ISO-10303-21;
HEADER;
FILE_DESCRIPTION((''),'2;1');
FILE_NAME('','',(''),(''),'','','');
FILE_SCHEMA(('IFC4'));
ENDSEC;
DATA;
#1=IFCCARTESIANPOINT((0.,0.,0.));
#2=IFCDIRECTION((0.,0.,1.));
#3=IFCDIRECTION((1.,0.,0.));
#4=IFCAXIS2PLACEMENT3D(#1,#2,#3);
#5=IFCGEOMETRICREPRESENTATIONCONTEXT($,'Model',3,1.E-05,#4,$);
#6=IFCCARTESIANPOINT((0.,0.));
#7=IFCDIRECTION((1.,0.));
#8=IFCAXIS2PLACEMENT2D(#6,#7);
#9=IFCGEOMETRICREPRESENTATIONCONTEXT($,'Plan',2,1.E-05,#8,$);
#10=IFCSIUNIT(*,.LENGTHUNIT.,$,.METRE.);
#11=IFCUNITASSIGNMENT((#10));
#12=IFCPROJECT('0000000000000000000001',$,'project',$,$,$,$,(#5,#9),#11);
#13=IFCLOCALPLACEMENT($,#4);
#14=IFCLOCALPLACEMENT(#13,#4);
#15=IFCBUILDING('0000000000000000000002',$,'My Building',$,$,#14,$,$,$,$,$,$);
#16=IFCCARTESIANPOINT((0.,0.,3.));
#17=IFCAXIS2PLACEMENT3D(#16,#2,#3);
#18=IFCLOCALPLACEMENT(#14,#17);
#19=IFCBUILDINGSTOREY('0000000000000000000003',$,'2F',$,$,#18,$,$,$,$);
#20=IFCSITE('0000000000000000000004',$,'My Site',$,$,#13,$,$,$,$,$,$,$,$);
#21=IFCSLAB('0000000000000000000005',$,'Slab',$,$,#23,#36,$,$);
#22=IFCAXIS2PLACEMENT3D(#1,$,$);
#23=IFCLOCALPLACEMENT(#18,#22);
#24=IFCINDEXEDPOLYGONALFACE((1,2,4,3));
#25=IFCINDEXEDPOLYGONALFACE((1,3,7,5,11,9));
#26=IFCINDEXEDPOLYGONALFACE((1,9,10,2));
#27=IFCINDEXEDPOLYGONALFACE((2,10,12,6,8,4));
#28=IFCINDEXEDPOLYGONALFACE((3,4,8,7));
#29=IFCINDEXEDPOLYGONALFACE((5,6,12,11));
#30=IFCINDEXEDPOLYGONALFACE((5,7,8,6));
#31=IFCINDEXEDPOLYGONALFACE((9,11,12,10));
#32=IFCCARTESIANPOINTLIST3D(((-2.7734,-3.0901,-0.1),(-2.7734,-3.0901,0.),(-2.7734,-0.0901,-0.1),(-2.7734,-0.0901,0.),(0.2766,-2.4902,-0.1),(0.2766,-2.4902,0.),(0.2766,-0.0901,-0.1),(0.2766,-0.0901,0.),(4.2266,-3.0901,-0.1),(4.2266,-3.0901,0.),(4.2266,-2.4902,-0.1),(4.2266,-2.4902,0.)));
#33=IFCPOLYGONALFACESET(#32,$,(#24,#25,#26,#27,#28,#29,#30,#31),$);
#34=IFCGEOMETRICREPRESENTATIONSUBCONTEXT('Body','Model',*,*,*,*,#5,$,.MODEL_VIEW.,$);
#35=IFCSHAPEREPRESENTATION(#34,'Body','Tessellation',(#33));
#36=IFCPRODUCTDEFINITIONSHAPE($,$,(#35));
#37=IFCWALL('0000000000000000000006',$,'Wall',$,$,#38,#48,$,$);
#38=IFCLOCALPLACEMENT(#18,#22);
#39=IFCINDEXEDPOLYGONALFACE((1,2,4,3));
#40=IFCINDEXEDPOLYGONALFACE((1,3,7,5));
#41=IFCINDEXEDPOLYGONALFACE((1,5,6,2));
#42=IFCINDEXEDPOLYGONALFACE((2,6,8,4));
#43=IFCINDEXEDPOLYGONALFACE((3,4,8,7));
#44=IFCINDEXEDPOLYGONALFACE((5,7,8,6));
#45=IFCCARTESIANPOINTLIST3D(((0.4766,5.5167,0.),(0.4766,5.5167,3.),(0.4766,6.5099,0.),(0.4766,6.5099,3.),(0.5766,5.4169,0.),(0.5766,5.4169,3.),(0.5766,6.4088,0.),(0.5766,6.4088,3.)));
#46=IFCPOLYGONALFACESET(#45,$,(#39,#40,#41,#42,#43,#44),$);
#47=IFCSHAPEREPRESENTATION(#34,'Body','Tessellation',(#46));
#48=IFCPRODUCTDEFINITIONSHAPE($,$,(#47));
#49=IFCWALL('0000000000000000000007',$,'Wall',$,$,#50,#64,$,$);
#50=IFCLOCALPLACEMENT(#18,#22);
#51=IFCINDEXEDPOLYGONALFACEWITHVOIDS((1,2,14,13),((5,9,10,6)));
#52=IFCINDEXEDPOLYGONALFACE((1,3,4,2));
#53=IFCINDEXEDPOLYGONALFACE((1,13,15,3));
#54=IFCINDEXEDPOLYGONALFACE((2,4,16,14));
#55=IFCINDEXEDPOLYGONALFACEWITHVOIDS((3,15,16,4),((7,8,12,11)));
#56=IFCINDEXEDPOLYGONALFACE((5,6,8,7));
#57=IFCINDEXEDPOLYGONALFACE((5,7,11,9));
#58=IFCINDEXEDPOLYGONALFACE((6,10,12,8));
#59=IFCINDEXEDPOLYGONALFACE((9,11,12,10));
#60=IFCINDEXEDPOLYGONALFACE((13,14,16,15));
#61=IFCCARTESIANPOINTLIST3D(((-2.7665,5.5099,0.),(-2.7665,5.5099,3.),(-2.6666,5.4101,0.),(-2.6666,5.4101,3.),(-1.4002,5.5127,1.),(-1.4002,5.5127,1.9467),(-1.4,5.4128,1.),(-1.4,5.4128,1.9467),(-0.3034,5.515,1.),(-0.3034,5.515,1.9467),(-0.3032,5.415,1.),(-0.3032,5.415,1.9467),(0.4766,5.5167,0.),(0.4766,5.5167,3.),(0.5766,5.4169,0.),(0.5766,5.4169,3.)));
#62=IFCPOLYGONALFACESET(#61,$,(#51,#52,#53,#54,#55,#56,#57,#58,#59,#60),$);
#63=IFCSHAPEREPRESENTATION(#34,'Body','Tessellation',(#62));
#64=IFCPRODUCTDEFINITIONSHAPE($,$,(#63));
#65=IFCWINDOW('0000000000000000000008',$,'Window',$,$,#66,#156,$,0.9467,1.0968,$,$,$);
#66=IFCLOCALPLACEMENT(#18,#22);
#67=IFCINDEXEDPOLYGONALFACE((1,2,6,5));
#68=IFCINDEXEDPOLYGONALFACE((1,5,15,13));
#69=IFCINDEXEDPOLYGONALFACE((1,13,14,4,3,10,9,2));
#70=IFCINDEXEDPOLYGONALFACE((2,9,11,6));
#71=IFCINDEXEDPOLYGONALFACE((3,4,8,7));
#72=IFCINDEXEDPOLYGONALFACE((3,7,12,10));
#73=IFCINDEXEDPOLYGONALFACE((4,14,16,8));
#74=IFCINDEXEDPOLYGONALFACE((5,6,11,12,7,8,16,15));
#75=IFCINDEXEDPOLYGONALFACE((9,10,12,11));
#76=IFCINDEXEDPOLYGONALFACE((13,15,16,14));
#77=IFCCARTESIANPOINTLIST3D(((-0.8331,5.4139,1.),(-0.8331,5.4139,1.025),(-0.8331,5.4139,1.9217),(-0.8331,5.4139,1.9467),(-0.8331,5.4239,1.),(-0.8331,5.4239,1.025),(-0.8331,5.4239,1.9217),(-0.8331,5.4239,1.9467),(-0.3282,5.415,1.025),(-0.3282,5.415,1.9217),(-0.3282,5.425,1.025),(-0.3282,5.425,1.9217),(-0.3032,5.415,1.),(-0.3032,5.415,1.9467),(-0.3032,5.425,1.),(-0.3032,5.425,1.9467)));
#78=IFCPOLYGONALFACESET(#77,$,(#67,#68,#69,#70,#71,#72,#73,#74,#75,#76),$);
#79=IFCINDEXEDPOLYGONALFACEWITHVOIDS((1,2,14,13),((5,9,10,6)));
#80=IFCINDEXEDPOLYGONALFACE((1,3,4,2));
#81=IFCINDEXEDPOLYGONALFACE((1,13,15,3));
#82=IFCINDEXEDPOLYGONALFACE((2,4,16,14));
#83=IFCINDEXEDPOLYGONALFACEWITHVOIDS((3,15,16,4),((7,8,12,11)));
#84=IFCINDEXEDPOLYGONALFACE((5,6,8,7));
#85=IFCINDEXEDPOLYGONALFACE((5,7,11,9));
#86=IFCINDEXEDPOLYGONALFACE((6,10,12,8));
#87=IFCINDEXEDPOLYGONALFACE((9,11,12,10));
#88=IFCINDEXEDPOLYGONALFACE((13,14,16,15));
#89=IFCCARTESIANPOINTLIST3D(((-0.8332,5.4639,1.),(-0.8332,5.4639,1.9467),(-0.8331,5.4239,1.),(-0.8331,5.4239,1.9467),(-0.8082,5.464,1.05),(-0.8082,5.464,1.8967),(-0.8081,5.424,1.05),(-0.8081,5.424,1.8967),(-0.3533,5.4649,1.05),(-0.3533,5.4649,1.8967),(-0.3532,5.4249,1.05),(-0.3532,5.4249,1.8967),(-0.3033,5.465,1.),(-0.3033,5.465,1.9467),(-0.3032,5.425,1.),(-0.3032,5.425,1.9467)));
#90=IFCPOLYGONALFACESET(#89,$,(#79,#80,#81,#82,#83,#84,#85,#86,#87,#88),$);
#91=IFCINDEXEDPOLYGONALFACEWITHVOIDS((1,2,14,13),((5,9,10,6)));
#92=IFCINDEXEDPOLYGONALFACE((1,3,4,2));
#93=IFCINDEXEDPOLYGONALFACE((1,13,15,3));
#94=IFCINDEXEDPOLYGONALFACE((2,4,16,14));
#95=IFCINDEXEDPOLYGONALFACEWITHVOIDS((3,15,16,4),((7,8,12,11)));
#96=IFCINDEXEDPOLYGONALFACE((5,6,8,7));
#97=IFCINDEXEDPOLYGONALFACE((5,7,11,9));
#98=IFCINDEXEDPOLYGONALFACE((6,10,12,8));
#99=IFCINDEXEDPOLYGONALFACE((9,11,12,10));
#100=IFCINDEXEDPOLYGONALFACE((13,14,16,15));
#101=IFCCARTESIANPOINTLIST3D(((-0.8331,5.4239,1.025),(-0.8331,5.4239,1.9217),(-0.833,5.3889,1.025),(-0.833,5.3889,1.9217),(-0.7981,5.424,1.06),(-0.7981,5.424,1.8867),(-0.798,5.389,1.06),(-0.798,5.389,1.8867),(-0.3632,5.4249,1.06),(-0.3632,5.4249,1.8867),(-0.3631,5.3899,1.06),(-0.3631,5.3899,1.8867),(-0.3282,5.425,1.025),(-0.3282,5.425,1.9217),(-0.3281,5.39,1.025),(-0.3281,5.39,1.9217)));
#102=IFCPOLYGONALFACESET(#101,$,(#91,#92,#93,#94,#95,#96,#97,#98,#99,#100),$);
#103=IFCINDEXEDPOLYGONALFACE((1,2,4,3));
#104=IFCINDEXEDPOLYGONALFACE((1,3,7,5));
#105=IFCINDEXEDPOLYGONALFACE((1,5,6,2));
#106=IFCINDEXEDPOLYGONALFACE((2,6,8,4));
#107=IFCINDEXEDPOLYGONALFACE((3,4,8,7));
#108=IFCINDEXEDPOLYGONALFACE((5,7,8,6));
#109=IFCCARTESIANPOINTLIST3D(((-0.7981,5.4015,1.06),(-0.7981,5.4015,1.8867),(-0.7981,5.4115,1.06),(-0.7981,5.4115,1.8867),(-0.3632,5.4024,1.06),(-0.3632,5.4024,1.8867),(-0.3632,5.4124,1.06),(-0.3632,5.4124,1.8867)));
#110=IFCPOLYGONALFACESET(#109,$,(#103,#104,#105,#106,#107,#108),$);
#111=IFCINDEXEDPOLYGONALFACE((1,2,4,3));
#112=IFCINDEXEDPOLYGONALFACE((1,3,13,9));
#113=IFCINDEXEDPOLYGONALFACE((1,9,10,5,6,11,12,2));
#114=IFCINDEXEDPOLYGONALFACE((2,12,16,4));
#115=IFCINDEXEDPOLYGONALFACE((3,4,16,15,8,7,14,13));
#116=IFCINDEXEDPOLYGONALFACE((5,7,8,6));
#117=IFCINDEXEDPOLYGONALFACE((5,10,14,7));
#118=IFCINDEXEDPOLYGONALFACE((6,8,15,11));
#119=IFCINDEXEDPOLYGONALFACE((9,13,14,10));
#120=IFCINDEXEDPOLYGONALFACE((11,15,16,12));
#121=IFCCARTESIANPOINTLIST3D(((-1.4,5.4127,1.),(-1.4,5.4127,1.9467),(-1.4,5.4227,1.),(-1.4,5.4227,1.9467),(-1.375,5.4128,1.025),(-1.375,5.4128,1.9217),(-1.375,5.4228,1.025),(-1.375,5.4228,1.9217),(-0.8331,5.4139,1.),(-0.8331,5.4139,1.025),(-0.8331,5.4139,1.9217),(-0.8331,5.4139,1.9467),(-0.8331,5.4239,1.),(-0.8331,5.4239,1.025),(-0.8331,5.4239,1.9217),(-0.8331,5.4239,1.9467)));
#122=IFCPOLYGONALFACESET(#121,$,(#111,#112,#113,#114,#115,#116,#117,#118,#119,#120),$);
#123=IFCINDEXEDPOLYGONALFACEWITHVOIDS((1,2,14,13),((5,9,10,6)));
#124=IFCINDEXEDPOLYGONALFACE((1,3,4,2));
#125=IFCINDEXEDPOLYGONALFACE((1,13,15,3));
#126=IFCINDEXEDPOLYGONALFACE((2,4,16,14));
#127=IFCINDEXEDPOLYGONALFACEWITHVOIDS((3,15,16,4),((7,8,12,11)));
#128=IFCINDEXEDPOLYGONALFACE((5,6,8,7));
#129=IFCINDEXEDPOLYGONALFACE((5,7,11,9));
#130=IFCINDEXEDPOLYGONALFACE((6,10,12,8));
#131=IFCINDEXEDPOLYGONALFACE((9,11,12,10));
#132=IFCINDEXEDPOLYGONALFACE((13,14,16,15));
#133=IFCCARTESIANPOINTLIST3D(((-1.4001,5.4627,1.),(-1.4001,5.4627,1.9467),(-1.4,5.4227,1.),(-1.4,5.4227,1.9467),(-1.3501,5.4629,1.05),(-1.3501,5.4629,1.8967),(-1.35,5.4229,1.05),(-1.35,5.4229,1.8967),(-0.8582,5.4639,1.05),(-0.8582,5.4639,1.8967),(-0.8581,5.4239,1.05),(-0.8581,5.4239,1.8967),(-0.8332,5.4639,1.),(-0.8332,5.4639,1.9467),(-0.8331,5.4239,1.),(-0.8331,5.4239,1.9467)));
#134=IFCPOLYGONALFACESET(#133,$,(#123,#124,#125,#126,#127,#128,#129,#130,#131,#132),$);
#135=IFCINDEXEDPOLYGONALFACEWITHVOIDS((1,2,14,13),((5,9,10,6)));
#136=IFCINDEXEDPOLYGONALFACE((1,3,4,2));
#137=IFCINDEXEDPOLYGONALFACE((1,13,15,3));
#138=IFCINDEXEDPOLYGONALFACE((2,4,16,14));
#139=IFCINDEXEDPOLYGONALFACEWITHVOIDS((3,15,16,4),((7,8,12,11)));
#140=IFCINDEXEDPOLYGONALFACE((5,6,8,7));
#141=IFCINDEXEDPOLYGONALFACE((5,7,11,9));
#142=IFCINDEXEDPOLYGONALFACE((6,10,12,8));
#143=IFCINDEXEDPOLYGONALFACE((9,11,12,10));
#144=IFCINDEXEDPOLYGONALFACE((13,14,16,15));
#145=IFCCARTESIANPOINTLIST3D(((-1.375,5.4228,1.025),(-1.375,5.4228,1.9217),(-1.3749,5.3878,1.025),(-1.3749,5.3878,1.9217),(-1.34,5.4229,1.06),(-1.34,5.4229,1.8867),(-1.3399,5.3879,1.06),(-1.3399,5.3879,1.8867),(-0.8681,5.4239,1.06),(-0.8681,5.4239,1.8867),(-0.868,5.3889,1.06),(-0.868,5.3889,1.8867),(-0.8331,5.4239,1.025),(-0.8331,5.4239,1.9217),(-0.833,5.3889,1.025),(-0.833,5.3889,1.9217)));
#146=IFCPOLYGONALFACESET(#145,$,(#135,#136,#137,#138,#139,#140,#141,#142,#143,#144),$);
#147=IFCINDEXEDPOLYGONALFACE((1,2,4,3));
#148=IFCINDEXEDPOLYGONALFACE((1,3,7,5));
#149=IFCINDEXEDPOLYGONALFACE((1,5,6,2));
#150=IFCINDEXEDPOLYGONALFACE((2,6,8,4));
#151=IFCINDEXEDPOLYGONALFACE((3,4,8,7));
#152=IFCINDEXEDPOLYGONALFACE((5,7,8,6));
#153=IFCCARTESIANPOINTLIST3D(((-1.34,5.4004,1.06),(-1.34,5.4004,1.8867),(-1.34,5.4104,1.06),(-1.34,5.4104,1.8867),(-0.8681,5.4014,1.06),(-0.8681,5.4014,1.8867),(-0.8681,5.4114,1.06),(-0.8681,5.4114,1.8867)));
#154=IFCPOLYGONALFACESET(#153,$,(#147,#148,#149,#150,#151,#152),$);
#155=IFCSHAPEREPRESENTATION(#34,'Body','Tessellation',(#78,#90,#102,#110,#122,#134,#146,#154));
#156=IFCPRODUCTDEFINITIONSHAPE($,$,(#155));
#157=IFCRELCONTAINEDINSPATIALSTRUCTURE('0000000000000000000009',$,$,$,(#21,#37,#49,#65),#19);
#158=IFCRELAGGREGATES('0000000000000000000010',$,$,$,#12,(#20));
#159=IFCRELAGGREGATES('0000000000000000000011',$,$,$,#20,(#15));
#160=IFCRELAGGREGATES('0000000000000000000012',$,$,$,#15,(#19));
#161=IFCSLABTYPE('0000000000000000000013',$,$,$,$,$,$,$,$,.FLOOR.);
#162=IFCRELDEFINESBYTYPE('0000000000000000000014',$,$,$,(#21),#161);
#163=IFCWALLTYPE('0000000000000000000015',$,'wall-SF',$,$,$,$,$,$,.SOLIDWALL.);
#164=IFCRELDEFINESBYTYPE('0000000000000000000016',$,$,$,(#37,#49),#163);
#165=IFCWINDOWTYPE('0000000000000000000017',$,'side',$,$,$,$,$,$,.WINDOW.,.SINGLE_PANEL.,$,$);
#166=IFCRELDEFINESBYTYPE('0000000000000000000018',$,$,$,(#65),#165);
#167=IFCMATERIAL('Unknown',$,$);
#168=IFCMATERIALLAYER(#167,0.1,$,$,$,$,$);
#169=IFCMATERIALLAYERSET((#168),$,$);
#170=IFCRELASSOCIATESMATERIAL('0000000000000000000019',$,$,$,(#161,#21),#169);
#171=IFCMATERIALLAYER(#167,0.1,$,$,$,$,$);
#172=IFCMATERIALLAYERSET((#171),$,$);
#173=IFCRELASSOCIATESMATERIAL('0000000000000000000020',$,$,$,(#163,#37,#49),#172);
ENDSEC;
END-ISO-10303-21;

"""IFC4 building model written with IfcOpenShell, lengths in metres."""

from ifc_helpers import new_model, entity, si_unit, frame, origin_with_axes, origin_2d_with_axis, place, context, subcontext, project, spatial, line, indexed_curve, outline, extrude, shape, source, transform, mapped, material, layer, layer_set, layer_usage, type_object, type_shapes, element, fill, save


model = new_model("IFC4")

# Units and contexts
model_context = context("Model", 3, precision=1e-05, world=origin_with_axes())
plan_context = context("Plan", 2, precision=1e-05, world=origin_2d_with_axis())
body_context_1 = subcontext(model_context, "Body", "Model", "MODEL_VIEW")
body_context_2 = subcontext(plan_context, "Body", "Plan", "PLAN_VIEW")
ifc_project = project(units=[si_unit("LENGTHUNIT", "METRE")], contexts=[model_context, plan_context])

# Site, building, storey
site_placement = place(None, origin_with_axes())
site = spatial("IfcSite", under=ifc_project, at=site_placement, Name="My Site")
building_placement = place(site_placement, origin_with_axes())
building = spatial("IfcBuilding", under=site, at=building_placement, Name="My Building")
storey_placement = place(building_placement, frame((0.0, 0.0, 3.0), z_axis=(0.0, 0.0, 1.0), x_axis=(1.0, 0.0, 0.0)))
storey = spatial("IfcBuildingStorey", under=building, at=storey_placement, Name="2F")

# Slab
ifc_material = material(Name="Unknown")
ifc_layer_1 = layer(ifc_material, 0.1)
ifc_layer_set_1 = layer_set([ifc_layer_1])
ifc_layer_usage_1 = layer_usage(ifc_layer_set_1, "AXIS3", "POSITIVE", -0.1)
slab_type = type_object("IfcSlabType", PredefinedType="FLOOR", material=ifc_layer_set_1)
slab_placement = place(storey_placement, frame((-2.7734, -0.0901, 0.0), z_axis=(0.0, 0.0, 1.0), x_axis=(1.0, 0.0, 0.0)))
element("IfcSlab", 1, at=slab_placement, inside=storey, type_object=slab_type, material=ifc_layer_usage_1, Name="Slab", context=body_context_1, shape_type="SweptSolid", body=[
    extrude(outline(indexed_curve([(0.0, 0.0), (0.0, -3.0), (7.0, -3.0), (7.0, -2.4001), (3.05, -2.4001), (3.05, 0.0), (0.0, 0.0), (0.0, 0.0)])), frame((0.0, 0.0, -0.1), z_axis=(0.0, 0.0, 1.0), x_axis=(1.0, 0.0, 0.0)), (0.0, 0.0, 1.0), 0.1),
])

# Wall
ifc_layer_2 = layer(ifc_material, 0.1)
ifc_layer_set_2 = layer_set([ifc_layer_2])
ifc_layer_usage_2 = layer_usage(ifc_layer_set_2, "AXIS2", "POSITIVE", 0.0)
wall_type = type_object("IfcWallType", Name="wall-SF", PredefinedType="SOLIDWALL", material=ifc_layer_set_2)
wall_1_placement = place(storey_placement, frame((0.4766, 6.5099, 0.0), z_axis=(0.0, 0.0, 1.0), x_axis=(0.0, -1.0, 0.0)))
element("IfcWall", 2, at=wall_1_placement, inside=storey, type_object=wall_type, material=ifc_layer_usage_2, Name="Wall", context=body_context_1, shape_type="SweptSolid", body=[
    extrude(outline(indexed_curve([(0.0, 0.0), (0.1011, 0.1), (1.093, 0.1), (0.9932, 0.0)], segments=[line(1, 2, 3, 4, 1)])), origin_with_axes(), (0.0, 0.0, 1.0), 3.0),
])

# Wall, opening, window
ifc_layer_usage_3 = layer_usage(ifc_layer_set_2, "AXIS2", "POSITIVE", 0.0)
wall_2_placement = place(storey_placement, frame((0.4766, 5.5167, 0.0), z_axis=(0.0, 0.0, 1.0), x_axis=(-0.999998, -0.00209, 0.0)))
wall_2 = element("IfcWall", 3, at=wall_2_placement, inside=storey, type_object=wall_type, material=ifc_layer_usage_3, Name="Wall", context=body_context_1, shape_type="SweptSolid", body=[
    extrude(outline(indexed_curve([(0.0, 0.0), (-0.0998, 0.1), (3.1434, 0.1), (3.2431, 0.0)], segments=[line(1, 2, 3, 4, 1)])), origin_with_axes(), (0.0, 0.0, 1.0), 3.0),
])
shared_shape_1 = source(origin_with_axes(), body_context_1, "Body", "SweptSolid", [
    extrude(outline(indexed_curve([(0.0, 0.0), (1.0968, 0.0), (1.0968, 0.9467), (0.0, 0.9467)], segments=[line(1, 2, 3, 4, 1)])), frame((0.0, -0.6, 0.0), z_axis=(0.0, -1.0, 0.0), x_axis=(1.0, 0.0, 0.0)), (0.0, 0.0, -1.0), 1.2),
])
opening_1_placement = place(wall_2_placement, frame((0.78, 0.0, 1.0), z_axis=(0.0, 0.0, 1.0), x_axis=(1.0, 0.0, 0.0)))
opening_1 = element("IfcOpeningElement", 4, at=opening_1_placement, cuts=wall_2, PredefinedType="OPENING", context=body_context_1, shape_type="MappedRepresentation", body=[
    mapped(shared_shape_1, transform((0.0, 0.0, 0.0), x_axis=(1.0, 0.0, 0.0), y_axis=(0.0, 1.0, 0.0), z_axis=(0.0, 0.0, 1.0), scale=1.0)),
])
window_type_1 = type_object("IfcWindowType", Name="side", PartitioningType="SINGLE_PANEL", PredefinedType="WINDOW")
shared_shape_2 = source(origin_with_axes(), body_context_1, "Body", "SweptSolid", [
    extrude(outline(indexed_curve([(0.5299, 0.0), (0.0, 0.0), (0.0, 0.9467), (0.5299, 0.9467), (0.5299, 0.9217), (0.025, 0.9217), (0.025, 0.025), (0.5299, 0.025)], segments=[line(1, 2, 3, 4, 5, 6, 7, 8, 1)])), frame((0.0, 0.09, 0.0), z_axis=(0.0, -1.0, 0.0), x_axis=(1.0, 0.0, 0.0)), (0.0, 0.0, -1.0), 0.01),
    extrude(outline(indexed_curve([(0.0, 0.0), (0.5299, 0.0), (0.5299, 0.9467), (0.0, 0.9467)], segments=[line(1, 2, 3, 4, 1)]), holes=[indexed_curve([(0.05, 0.05), (0.5049, 0.05), (0.5049, 0.8967), (0.05, 0.8967)], segments=[line(1, 2, 3, 4, 1)])]), frame((0.0, 0.05, 0.0), z_axis=(0.0, -1.0, 0.0), x_axis=(1.0, 0.0, 0.0)), (0.0, 0.0, -1.0), 0.04),
    extrude(outline(indexed_curve([(0.0, 0.0), (0.5049, 0.0), (0.5049, 0.8967), (0.0, 0.8967)], segments=[line(1, 2, 3, 4, 1)]), holes=[indexed_curve([(0.035, 0.035), (0.4699, 0.035), (0.4699, 0.8617), (0.035, 0.8617)], segments=[line(1, 2, 3, 4, 1)])]), frame((0.025, 0.09, 0.025), z_axis=(0.0, -1.0, 0.0), x_axis=(1.0, 0.0, 0.0)), (0.0, 0.0, -1.0), 0.035),
    extrude(outline(indexed_curve([(0.035, 0.035), (0.4699, 0.035), (0.4699, 0.8617), (0.035, 0.8617)], segments=[line(1, 2, 3, 4, 1)])), frame((0.025, 0.1025, 0.025), z_axis=(0.0, -1.0, 0.0), x_axis=(1.0, 0.0, 0.0)), (0.0, 0.0, -1.0), 0.01),
    extrude(outline(indexed_curve([(0.0, 0.9467), (0.5669, 0.9467), (0.5669, 0.0), (0.0, 0.0), (0.0, 0.025), (0.5419, 0.025), (0.5419, 0.9217), (0.0, 0.9217)], segments=[line(1, 2, 3, 4, 5, 6, 7, 8, 1)])), frame((0.5299, 0.09, 0.0), z_axis=(0.0, -1.0, 0.0), x_axis=(1.0, 0.0, 0.0)), (0.0, 0.0, -1.0), 0.01),
    extrude(outline(indexed_curve([(0.0, 0.0), (0.5669, 0.0), (0.5669, 0.9467), (0.0, 0.9467)], segments=[line(1, 2, 3, 4, 1)]), holes=[indexed_curve([(0.025, 0.05), (0.5169, 0.05), (0.5169, 0.8967), (0.025, 0.8967)], segments=[line(1, 2, 3, 4, 1)])]), frame((0.5299, 0.05, 0.0), z_axis=(0.0, -1.0, 0.0), x_axis=(1.0, 0.0, 0.0)), (0.0, 0.0, -1.0), 0.04),
    extrude(outline(indexed_curve([(0.0, 0.0), (0.5419, 0.0), (0.5419, 0.8967), (0.0, 0.8967)], segments=[line(1, 2, 3, 4, 1)]), holes=[indexed_curve([(0.035, 0.035), (0.5069, 0.035), (0.5069, 0.8617), (0.035, 0.8617)], segments=[line(1, 2, 3, 4, 1)])]), frame((0.5299, 0.09, 0.025), z_axis=(0.0, -1.0, 0.0), x_axis=(1.0, 0.0, 0.0)), (0.0, 0.0, -1.0), 0.035),
    extrude(outline(indexed_curve([(0.035, 0.035), (0.5069, 0.035), (0.5069, 0.8617), (0.035, 0.8617)], segments=[line(1, 2, 3, 4, 1)])), frame((0.5299, 0.1025, 0.025), z_axis=(0.0, -1.0, 0.0), x_axis=(1.0, 0.0, 0.0)), (0.0, 0.0, -1.0), 0.01),
])
shared_shape_3 = source(origin_with_axes(), body_context_2, "Body", "Curve2D", [
    entity("IfcIndexedPolyCurve", entity("IfcCartesianPointList2D", [[0.05, 0.05], [0.5049, 0.05]])),
    entity("IfcIndexedPolyCurve", entity("IfcCartesianPointList2D", [[0.0, 0.1], [0.025, 0.1], [0.025, 0.09], [0.05, 0.09], [0.05, 0.05], [0.0, 0.05]]), [entity("IfcLineIndex", [1, 2, 3, 4, 5, 6, 1])]),
    entity("IfcIndexedPolyCurve", entity("IfcCartesianPointList2D", [[0.5299, 0.1], [0.5299, 0.1], [0.5299, 0.09], [0.5049, 0.09], [0.5049, 0.05], [0.5299, 0.05]])),
    entity("IfcIndexedPolyCurve", entity("IfcCartesianPointList2D", [[0.025, 0.09], [0.06, 0.09], [0.06, 0.125], [0.025, 0.125]]), [entity("IfcLineIndex", [1, 2, 3, 4, 1])]),
    entity("IfcIndexedPolyCurve", entity("IfcCartesianPointList2D", [[0.5299, 0.09], [0.4949, 0.09], [0.4949, 0.125], [0.5299, 0.125]]), [entity("IfcLineIndex", [1, 2, 3, 4, 1])]),
    entity("IfcIndexedPolyCurve", entity("IfcCartesianPointList2D", [[0.06, 0.09], [0.4949, 0.09]])),
    entity("IfcIndexedPolyCurve", entity("IfcCartesianPointList2D", [[0.06, 0.125], [0.4949, 0.125]])),
    entity("IfcIndexedPolyCurve", entity("IfcCartesianPointList2D", [[0.06, 0.1075], [0.4949, 0.1075]])),
    entity("IfcIndexedPolyCurve", entity("IfcCartesianPointList2D", [[0.5549, 0.05], [1.0468, 0.05]])),
    entity("IfcIndexedPolyCurve", entity("IfcCartesianPointList2D", [[0.5299, 0.1], [0.5299, 0.1], [0.5299, 0.09], [0.5549, 0.09], [0.5549, 0.05], [0.5299, 0.05]])),
    entity("IfcIndexedPolyCurve", entity("IfcCartesianPointList2D", [[1.0968, 0.1], [1.0718, 0.1], [1.0718, 0.09], [1.0468, 0.09], [1.0468, 0.05], [1.0968, 0.05]]), [entity("IfcLineIndex", [1, 2, 3, 4, 5, 6, 1])]),
    entity("IfcIndexedPolyCurve", entity("IfcCartesianPointList2D", [[0.5299, 0.09], [0.5649, 0.09], [0.5649, 0.125], [0.5299, 0.125]]), [entity("IfcLineIndex", [1, 2, 3, 4, 1])]),
    entity("IfcIndexedPolyCurve", entity("IfcCartesianPointList2D", [[1.0718, 0.09], [1.0368, 0.09], [1.0368, 0.125], [1.0718, 0.125]]), [entity("IfcLineIndex", [1, 2, 3, 4, 1])]),
    entity("IfcIndexedPolyCurve", entity("IfcCartesianPointList2D", [[0.5649, 0.09], [1.0368, 0.09]])),
    entity("IfcIndexedPolyCurve", entity("IfcCartesianPointList2D", [[0.5649, 0.125], [1.0368, 0.125]])),
    entity("IfcIndexedPolyCurve", entity("IfcCartesianPointList2D", [[0.5649, 0.1075], [1.0368, 0.1075]])),
])
type_shapes(window_type_1, [shared_shape_2, shared_shape_3])
window_1_placement = place(opening_1_placement, frame((0.0, 0.0, 0.0), z_axis=(0.0, 0.0, 1.0), x_axis=(1.0, 0.0, 0.0)))
window_1 = element("IfcWindow", 5, at=window_1_placement, inside=storey, type_object=window_type_1, Name="Window", OverallHeight=0.9467, OverallWidth=1.0968, shapes=[
    shape(body_context_1, "Body", "MappedRepresentation", [mapped(shared_shape_2, transform((0.0, 0.0, 0.0), x_axis=(1.0, 0.0, 0.0), y_axis=(0.0, 1.0, 0.0), z_axis=(0.0, 0.0, 1.0), scale=1.0))]),
    shape(body_context_2, "Body", "MappedRepresentation", [mapped(shared_shape_3, transform((0.0, 0.0, 0.0), x_axis=(1.0, 0.0, 0.0), y_axis=(0.0, 1.0, 0.0), z_axis=(0.0, 0.0, 1.0), scale=1.0))]),
])
fill(opening_1, window_1)

save(model, "model.ifc")
